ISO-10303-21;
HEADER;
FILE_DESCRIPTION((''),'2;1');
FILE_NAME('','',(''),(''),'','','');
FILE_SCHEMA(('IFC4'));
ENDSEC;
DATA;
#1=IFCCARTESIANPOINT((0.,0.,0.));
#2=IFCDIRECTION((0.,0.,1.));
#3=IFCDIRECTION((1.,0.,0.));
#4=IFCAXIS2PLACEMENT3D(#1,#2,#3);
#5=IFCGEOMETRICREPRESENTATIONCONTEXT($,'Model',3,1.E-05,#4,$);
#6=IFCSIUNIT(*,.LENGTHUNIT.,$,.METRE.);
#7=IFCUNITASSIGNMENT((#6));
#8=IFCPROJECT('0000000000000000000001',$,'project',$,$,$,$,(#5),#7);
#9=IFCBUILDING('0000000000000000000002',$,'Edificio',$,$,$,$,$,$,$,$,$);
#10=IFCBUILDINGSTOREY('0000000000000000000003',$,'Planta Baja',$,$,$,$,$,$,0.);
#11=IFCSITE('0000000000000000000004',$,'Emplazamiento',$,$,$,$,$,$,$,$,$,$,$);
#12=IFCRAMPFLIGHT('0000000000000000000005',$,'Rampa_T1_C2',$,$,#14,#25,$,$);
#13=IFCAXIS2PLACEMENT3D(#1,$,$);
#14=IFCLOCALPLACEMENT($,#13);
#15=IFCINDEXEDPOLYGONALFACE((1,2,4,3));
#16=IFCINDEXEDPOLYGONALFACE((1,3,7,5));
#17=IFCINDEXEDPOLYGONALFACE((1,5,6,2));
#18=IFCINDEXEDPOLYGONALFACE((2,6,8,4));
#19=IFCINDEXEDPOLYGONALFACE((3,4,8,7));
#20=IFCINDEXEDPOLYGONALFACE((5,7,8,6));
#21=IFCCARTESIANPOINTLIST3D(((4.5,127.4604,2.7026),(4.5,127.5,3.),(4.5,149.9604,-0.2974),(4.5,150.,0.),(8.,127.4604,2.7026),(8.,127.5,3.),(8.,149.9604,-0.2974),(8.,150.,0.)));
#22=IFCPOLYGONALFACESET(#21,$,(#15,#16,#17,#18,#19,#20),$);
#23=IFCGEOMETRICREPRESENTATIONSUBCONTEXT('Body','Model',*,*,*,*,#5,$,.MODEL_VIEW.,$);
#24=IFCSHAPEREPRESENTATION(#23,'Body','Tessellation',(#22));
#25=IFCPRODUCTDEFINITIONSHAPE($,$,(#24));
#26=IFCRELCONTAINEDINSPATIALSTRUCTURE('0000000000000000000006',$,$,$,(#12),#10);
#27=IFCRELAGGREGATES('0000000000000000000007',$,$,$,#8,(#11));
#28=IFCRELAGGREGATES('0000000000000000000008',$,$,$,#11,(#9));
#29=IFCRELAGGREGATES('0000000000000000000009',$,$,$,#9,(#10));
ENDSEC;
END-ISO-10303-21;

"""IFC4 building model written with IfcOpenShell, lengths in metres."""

from ifc_helpers import new_model, si_unit, frame, origin_with_axes, origin_2d, place, context, subcontext, project, spatial, rectangle, extrude, element, save


model = new_model("IFC4")

# Units and contexts
model_context = context("Model", 3, precision=1e-05, world=origin_with_axes())
body_context = subcontext(model_context, "Body", "Model", "MODEL_VIEW")
ifc_project = project(units=[si_unit("LENGTHUNIT", "METRE")], contexts=[model_context])

# Site, building, storey
site = spatial("IfcSite", under=ifc_project, Name="Emplazamiento")
building = spatial("IfcBuilding", under=site, Name="Edificio")
storey = spatial("IfcBuildingStorey", under=building, Name="Planta Baja", Elevation=0.0)

# Ramp flight
for number, where, z_axis, x_axis, name in (
    (1, (6.25, 138.7104, 1.2026), (0.0, 0.132164, 0.991228), (0.0, -0.991228, 0.132164), "Rampa_T1_C2"),
):
    element("IfcRampFlight", number, at=place(None, frame(where, z_axis=z_axis, x_axis=x_axis)), inside=storey, Name=name, context=body_context, shape_type="SweptSolid", body=[
        extrude(rectangle(XDim=22.6991, YDim=3.5, at=origin_2d()), origin_with_axes(), (0.0, 0.0, 1.0), 0.3),
    ])

save(model, "model.ifc")
